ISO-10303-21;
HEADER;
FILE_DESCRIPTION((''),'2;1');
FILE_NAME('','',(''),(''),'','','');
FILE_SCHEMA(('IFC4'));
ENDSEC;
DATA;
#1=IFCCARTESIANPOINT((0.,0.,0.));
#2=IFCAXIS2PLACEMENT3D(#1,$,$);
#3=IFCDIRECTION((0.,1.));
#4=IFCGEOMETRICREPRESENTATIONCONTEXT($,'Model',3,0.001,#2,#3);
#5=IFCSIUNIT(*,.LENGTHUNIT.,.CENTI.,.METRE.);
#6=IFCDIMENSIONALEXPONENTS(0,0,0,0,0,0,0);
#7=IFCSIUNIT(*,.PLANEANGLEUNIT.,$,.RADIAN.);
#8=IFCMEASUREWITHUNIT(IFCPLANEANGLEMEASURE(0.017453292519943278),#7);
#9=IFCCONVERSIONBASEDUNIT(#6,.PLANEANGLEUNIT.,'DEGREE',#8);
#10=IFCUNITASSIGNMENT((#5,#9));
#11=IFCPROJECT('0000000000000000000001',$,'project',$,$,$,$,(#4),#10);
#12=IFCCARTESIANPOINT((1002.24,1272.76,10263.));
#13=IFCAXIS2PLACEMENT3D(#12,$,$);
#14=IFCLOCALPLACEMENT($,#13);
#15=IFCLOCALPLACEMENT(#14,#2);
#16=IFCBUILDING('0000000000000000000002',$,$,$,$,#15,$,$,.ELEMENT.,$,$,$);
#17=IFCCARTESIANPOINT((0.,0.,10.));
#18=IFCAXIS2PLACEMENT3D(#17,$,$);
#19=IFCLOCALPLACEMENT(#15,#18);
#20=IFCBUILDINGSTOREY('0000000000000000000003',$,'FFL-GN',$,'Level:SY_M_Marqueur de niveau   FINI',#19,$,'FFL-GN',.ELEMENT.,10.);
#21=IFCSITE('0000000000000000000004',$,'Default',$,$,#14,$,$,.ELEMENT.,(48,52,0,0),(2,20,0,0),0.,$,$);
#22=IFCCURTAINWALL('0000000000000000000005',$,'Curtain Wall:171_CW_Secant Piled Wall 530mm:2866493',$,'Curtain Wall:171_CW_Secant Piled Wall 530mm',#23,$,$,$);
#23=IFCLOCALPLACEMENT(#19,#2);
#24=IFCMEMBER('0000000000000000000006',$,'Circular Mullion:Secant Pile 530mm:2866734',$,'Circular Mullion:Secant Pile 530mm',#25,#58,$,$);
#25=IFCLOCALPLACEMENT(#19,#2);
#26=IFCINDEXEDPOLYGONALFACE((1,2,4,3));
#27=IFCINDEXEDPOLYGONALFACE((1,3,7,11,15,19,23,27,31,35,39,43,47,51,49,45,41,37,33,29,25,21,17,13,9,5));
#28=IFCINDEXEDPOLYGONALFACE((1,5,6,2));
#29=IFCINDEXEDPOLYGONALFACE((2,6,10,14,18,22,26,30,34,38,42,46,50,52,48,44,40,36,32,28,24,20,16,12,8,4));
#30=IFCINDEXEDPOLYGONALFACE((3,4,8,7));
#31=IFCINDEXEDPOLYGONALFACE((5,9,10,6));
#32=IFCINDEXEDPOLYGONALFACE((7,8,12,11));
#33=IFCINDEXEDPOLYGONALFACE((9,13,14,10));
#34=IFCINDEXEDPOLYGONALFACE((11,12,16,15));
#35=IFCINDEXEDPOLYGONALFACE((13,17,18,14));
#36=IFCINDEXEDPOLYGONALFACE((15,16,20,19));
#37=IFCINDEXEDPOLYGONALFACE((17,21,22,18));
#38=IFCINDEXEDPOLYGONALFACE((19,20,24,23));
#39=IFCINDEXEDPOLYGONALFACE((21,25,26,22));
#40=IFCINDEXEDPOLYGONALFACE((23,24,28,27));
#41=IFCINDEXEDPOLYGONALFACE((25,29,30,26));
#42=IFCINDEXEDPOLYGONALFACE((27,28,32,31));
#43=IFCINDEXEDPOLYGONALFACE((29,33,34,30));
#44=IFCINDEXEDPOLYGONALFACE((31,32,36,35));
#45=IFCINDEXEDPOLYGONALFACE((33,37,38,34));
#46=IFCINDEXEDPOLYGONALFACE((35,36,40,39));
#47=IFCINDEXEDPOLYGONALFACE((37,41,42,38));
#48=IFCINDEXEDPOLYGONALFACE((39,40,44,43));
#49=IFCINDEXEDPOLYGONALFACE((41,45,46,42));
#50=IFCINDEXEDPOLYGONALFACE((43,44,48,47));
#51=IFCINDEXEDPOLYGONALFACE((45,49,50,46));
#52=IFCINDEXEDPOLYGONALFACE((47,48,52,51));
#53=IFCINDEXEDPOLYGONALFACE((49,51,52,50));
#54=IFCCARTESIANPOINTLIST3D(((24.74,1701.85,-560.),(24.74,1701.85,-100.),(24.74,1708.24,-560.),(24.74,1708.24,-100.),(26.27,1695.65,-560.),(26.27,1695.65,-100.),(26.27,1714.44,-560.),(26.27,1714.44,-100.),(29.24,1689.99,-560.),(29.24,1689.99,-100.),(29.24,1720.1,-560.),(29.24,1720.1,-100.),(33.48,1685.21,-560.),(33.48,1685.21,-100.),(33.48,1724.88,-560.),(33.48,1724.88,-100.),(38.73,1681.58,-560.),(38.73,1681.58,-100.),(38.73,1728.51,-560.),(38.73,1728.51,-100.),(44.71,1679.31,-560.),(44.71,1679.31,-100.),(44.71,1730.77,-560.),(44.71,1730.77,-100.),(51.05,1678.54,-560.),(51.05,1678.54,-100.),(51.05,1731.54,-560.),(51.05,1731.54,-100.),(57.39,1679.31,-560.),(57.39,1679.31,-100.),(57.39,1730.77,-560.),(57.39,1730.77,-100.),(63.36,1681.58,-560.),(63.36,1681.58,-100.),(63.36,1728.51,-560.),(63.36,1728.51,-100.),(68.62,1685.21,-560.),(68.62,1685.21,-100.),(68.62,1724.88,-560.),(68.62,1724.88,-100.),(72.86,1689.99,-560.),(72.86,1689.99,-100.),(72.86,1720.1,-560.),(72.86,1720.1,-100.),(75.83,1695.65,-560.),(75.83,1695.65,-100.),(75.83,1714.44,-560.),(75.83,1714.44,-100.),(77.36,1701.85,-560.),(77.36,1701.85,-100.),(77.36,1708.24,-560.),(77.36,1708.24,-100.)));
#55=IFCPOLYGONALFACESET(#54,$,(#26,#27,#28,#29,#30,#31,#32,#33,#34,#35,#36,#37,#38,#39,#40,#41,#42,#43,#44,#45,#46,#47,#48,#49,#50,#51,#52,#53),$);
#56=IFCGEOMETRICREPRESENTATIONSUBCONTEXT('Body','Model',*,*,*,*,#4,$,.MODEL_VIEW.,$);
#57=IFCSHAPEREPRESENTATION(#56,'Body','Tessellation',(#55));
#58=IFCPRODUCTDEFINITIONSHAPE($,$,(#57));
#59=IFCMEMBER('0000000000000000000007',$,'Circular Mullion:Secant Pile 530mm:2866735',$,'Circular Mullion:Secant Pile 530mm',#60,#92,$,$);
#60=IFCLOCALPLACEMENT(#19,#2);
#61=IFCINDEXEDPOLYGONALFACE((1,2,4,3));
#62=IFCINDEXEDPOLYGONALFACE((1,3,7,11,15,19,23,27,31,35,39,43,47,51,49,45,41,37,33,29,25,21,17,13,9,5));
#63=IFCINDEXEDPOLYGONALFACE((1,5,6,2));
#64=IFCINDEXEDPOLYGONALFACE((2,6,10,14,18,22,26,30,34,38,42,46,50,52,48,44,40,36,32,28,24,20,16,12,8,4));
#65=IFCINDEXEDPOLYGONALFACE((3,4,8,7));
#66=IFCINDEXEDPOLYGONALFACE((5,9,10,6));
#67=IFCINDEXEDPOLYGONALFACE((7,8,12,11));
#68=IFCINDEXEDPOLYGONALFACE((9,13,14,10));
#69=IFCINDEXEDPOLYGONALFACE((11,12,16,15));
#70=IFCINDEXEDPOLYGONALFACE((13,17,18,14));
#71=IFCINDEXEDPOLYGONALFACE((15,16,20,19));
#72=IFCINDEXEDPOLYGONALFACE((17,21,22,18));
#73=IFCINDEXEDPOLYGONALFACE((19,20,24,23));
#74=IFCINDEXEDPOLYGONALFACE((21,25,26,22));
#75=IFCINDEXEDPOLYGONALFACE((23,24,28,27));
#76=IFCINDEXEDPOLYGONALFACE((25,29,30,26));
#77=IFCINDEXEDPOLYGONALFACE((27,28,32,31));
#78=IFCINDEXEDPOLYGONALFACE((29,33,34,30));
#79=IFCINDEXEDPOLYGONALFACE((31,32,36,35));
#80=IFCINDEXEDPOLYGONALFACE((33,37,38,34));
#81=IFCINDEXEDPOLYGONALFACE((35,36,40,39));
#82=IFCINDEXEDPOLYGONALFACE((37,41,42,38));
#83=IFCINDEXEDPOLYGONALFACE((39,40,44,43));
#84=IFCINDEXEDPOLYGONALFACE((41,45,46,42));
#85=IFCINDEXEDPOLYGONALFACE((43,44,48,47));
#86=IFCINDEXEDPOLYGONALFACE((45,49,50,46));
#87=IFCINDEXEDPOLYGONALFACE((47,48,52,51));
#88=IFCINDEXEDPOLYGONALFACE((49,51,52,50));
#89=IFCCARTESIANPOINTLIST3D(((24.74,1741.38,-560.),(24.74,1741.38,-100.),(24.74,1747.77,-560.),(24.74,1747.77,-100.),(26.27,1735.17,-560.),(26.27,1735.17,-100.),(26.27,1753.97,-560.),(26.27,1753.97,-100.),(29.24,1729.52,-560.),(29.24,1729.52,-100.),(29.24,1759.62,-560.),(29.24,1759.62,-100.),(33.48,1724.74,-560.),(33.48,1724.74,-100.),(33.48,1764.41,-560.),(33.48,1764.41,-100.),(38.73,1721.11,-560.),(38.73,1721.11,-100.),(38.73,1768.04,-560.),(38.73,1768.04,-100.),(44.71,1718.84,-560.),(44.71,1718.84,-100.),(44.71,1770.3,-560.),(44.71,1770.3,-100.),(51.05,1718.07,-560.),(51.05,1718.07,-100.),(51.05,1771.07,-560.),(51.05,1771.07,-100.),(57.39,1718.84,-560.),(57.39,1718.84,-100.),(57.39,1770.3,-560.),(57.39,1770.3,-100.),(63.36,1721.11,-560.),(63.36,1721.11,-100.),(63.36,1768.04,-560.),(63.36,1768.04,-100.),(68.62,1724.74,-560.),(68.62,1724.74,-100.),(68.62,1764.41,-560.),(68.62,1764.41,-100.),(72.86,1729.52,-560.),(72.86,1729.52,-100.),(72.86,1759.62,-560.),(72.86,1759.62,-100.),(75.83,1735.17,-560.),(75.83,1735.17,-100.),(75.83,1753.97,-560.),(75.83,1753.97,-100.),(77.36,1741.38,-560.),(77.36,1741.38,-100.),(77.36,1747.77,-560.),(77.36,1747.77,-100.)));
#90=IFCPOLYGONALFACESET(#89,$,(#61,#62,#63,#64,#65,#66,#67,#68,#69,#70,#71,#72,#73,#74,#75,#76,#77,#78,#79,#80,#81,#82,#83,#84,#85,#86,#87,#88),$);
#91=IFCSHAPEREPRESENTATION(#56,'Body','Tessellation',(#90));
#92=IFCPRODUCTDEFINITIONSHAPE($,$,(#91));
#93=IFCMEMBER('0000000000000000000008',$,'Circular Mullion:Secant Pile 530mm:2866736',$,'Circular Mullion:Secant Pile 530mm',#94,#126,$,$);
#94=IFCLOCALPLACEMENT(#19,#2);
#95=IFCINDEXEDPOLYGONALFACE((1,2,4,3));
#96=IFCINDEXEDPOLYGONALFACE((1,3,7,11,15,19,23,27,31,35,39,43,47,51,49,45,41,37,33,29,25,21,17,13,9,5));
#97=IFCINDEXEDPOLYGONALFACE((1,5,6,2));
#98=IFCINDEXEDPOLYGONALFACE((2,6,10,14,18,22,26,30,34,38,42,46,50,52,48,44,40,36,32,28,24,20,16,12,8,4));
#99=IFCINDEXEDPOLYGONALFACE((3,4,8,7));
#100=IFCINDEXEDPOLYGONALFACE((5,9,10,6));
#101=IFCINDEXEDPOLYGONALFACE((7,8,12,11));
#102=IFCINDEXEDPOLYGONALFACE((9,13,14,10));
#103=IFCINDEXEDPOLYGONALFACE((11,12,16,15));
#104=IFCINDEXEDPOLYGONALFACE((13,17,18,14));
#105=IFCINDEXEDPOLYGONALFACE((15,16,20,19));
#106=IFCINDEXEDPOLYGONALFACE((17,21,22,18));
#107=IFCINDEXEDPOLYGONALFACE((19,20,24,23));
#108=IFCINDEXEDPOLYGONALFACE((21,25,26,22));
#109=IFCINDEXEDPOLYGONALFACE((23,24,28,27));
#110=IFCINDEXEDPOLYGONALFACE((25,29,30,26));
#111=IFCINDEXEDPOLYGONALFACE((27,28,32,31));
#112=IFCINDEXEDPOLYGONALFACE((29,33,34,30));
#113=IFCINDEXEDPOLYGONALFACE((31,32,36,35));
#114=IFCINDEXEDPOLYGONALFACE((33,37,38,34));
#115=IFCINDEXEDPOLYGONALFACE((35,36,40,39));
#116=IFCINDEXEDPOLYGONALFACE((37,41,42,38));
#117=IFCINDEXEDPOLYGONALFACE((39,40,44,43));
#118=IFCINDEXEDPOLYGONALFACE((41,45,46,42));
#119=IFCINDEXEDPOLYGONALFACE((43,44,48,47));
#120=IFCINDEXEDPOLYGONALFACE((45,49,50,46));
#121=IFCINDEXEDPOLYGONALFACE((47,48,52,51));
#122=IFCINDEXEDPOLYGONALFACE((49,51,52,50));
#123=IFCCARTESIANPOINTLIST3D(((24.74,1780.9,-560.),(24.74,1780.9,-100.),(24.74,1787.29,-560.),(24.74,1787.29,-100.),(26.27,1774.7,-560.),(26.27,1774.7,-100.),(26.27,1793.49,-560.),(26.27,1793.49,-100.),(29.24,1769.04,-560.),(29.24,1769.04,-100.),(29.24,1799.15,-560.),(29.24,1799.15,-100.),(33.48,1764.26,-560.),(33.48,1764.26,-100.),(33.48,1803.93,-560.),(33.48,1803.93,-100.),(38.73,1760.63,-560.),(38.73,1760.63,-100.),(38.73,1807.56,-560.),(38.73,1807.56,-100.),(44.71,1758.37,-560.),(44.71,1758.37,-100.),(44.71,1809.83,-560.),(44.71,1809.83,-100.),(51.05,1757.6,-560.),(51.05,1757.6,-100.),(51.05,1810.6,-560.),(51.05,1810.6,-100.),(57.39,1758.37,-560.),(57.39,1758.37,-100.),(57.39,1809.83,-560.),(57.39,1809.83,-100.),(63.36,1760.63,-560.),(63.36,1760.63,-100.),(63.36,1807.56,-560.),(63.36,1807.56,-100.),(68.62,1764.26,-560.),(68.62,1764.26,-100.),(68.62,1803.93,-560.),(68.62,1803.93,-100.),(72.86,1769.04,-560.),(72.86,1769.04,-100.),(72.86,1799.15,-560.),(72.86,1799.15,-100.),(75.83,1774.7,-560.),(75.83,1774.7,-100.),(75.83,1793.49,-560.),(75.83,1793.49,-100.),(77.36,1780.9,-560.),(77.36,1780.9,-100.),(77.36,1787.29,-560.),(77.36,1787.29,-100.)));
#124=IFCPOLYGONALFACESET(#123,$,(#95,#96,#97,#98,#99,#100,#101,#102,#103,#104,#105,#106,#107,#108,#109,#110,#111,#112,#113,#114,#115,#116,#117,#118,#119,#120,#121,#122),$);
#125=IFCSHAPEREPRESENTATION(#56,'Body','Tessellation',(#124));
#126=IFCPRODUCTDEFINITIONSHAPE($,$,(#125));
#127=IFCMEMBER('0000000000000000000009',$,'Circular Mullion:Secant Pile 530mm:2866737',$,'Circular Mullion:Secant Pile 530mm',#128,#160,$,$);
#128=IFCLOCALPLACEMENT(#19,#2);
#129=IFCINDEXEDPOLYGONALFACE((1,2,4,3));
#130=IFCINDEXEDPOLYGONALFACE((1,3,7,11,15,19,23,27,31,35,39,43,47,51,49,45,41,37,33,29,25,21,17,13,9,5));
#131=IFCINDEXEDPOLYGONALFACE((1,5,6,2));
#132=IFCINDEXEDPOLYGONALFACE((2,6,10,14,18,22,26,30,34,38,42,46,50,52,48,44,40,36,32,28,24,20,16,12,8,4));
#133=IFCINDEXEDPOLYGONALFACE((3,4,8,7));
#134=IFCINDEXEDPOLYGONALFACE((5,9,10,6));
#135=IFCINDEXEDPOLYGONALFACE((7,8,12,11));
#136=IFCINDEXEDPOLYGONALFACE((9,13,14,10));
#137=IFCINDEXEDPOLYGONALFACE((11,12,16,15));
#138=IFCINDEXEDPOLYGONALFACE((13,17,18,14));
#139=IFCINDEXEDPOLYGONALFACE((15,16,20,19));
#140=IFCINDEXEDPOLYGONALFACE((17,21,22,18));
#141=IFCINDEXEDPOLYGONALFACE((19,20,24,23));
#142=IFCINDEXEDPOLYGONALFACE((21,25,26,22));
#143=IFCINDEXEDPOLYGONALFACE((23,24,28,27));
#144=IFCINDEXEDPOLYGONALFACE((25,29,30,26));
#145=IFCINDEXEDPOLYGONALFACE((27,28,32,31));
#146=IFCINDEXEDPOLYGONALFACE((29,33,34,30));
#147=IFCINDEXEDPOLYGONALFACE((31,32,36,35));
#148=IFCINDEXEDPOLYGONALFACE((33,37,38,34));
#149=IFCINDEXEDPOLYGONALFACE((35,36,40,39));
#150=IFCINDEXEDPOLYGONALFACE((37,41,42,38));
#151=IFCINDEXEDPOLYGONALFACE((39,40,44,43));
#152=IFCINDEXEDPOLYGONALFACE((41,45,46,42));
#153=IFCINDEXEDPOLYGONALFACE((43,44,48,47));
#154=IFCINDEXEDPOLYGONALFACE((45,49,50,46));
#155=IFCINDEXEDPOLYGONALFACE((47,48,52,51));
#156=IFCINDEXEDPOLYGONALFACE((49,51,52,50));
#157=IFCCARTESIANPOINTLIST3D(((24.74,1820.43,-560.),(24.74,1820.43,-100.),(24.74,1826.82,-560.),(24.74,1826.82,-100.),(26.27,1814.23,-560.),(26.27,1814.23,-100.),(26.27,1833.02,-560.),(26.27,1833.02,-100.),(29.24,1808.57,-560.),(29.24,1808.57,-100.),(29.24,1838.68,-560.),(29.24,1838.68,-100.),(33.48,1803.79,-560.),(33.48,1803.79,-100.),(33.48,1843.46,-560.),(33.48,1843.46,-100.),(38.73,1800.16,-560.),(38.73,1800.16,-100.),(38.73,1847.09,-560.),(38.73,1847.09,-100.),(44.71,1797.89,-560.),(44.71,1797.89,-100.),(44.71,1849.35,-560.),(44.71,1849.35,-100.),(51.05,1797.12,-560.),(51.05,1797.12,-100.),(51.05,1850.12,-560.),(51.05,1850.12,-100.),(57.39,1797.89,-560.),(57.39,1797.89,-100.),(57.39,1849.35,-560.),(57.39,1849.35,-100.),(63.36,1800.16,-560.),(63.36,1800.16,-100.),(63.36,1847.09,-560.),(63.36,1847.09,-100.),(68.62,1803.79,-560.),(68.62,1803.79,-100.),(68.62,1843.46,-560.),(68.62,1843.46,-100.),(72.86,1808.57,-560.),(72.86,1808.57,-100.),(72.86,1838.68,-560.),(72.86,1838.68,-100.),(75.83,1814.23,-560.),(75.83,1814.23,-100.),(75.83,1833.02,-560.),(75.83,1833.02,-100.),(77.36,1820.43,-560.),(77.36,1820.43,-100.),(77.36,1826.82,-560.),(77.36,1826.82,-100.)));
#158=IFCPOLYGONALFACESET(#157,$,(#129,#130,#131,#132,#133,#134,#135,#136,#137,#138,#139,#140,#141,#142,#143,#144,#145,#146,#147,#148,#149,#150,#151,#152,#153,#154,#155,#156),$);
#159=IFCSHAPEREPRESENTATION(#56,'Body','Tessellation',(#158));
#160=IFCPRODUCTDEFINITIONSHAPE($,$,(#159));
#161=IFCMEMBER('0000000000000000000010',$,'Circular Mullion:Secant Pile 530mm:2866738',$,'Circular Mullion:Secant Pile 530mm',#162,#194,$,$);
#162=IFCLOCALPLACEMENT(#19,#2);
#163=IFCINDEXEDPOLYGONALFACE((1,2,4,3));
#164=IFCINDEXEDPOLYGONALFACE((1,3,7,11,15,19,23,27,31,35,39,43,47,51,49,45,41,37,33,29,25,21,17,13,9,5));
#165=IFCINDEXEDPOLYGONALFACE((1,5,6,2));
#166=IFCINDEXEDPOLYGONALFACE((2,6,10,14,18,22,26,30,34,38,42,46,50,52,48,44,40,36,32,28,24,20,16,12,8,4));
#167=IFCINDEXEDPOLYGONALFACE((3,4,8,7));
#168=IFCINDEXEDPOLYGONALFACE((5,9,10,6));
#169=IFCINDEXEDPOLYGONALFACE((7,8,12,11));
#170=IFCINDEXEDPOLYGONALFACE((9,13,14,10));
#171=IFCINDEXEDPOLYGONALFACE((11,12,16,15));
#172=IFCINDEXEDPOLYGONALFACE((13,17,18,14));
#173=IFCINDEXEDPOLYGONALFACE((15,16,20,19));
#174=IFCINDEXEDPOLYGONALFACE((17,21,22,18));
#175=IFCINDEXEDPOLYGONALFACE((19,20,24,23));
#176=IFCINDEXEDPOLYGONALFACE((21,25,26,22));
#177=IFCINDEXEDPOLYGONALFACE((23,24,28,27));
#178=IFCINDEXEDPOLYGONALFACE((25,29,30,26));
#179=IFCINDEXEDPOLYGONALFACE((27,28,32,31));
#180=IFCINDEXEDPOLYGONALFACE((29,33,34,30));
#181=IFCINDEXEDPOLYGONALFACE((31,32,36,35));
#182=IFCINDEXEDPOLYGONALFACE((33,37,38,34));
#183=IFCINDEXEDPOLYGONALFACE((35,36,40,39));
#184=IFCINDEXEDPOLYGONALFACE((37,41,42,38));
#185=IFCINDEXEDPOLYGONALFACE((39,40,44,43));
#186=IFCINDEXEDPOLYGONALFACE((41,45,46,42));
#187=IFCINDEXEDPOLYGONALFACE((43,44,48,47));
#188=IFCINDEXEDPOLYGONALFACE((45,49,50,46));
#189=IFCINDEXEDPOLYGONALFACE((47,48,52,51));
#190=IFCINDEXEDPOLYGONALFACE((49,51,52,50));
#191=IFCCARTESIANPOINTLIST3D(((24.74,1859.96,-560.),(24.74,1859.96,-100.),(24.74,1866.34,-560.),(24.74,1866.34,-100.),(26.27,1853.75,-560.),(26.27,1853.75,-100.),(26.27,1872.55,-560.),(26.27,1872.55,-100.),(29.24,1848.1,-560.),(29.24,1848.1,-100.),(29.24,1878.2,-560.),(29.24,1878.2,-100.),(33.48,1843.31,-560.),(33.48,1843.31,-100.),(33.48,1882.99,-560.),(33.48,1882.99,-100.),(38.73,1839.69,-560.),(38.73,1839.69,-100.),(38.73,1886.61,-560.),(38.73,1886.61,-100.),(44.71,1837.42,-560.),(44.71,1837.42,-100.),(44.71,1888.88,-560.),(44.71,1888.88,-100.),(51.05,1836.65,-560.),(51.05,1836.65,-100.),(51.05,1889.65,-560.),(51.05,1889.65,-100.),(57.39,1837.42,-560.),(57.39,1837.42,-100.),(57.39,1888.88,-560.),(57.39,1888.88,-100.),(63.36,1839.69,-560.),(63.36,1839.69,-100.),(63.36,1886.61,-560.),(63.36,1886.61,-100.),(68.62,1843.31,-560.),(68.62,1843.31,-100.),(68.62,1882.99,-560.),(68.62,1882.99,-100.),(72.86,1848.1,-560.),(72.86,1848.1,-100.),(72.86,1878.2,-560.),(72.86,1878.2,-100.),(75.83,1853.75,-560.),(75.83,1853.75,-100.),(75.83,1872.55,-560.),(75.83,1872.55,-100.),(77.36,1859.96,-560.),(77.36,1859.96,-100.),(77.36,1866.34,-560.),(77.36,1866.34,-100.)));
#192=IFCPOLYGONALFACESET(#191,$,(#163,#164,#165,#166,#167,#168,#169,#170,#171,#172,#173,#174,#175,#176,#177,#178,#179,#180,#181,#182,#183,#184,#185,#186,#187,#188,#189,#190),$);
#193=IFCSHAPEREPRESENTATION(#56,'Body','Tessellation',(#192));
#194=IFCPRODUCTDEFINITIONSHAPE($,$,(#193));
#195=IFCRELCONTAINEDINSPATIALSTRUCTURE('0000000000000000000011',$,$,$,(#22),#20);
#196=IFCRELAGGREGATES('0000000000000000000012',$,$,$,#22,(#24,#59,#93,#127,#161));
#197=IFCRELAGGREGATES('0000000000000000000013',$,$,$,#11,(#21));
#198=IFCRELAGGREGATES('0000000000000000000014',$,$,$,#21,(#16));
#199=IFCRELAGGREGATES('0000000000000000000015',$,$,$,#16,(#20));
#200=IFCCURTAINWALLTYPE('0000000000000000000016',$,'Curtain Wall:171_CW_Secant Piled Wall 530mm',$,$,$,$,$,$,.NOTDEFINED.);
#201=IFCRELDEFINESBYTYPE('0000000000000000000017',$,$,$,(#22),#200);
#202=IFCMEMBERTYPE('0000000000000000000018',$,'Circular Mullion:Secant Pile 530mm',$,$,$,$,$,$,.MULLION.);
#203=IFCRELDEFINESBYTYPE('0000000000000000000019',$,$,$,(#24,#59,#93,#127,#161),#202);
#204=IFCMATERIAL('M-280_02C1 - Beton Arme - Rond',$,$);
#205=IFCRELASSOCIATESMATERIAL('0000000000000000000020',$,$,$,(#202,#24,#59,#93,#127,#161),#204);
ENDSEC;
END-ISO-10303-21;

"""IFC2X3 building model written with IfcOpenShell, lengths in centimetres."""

from ifc_helpers import new_model, entity, si_unit, converted_unit, direction, frame, frame_2d, origin, place, context, subcontext, project, spatial, circle, extrude, source, transform, mapped, material, type_object, type_shapes, element, aggregate, save


model = new_model("IFC2X3")

# Units and contexts
model_context = context("Model", 3, precision=0.001, world=origin(), true_north=direction((0.0, 1.0)))
body_context = subcontext(model_context, "Body", "Model", "MODEL_VIEW")
ifc_project = project(units=[si_unit("LENGTHUNIT", "METRE", prefix="CENTI"), converted_unit("PLANEANGLEUNIT", "DEGREE", entity("IfcPlaneAngleMeasure", 0.017453292519943278), si_unit("PLANEANGLEUNIT", "RADIAN"), dimensions=[0, 0, 0, 0, 0, 0, 0])], contexts=[model_context])

# Site, building, storey
site_placement = place(None, frame((1002.24, 1272.76, 10263.0)))
site = spatial("IfcSite", under=ifc_project, at=site_placement, Name="Default", CompositionType="ELEMENT", RefLatitude=(48, 52, 0, 0), RefLongitude=(2, 20, 0, 0), RefElevation=0.0)
building_placement = place(site_placement, origin())
building = spatial("IfcBuilding", under=site, at=building_placement, CompositionType="ELEMENT")
storey_placement = place(building_placement, frame((0.0, 0.0, 10.0)))
storey = spatial("IfcBuildingStorey", under=building, at=storey_placement, Name="FFL-GN", ObjectType="Level:SY_M_Marqueur de niveau   FINI", LongName="FFL-GN", CompositionType="ELEMENT", Elevation=10.0)

# Curtain wall, members
curtain_wall_type = type_object("IfcCurtainWallType", Name="Curtain Wall:171_CW_Secant Piled Wall 530mm", PredefinedType="NOTDEFINED")
curtain_wall_placement = place(storey_placement, frame((0.0, 0.0, -10.0)))
curtain_wall = element("IfcCurtainWall", 1, at=curtain_wall_placement, inside=storey, type_object=curtain_wall_type, Name="Curtain Wall:171_CW_Secant Piled Wall 530mm:2866493", ObjectType="Curtain Wall:171_CW_Secant Piled Wall 530mm")
ifc_material_1 = material(Name="M-280_02C1 - Beton Arme - Rond")
member_type = type_object("IfcMemberType", Name="Circular Mullion:Secant Pile 530mm", PredefinedType="MULLION", material=ifc_material_1)
shared_shape = source(origin(), body_context, "Body", "SweptSolid", [
    extrude(circle(Radius=26.5, at=frame_2d((0.0, 0.0), x_axis=(1.0, 0.0))), frame((0.0, 0.0, -460.0)), (0.0, 0.0, 1.0), 460.0),
])
type_shapes(member_type, [shared_shape])
member_1_placement = place(curtain_wall_placement, frame((51.05, 1705.04, -550.0), z_axis=(0.0, 0.0, -1.0), x_axis=(0.0, 1.0, 0.0)))
member_1 = element("IfcMember", 2, at=member_1_placement, type_object=member_type, material=ifc_material_1, Name="Circular Mullion:Secant Pile 530mm:2866734", ObjectType="Circular Mullion:Secant Pile 530mm", context=body_context, shape_type="MappedRepresentation", body=[
    mapped(shared_shape, transform((0.0, 0.0, 0.0), scale=1.0)),
])
member_2_placement = place(curtain_wall_placement, frame((51.05, 1744.57, -550.0), z_axis=(0.0, 0.0, -1.0), x_axis=(0.0, 1.0, 0.0)))
member_2 = element("IfcMember", 3, at=member_2_placement, type_object=member_type, material=ifc_material_1, Name="Circular Mullion:Secant Pile 530mm:2866735", ObjectType="Circular Mullion:Secant Pile 530mm", context=body_context, shape_type="MappedRepresentation", body=[
    mapped(shared_shape, transform((0.0, 0.0, 0.0), scale=1.0)),
])
member_3_placement = place(curtain_wall_placement, frame((51.05, 1784.1, -550.0), z_axis=(0.0, 0.0, -1.0), x_axis=(0.0, 1.0, 0.0)))
member_3 = element("IfcMember", 4, at=member_3_placement, type_object=member_type, material=ifc_material_1, Name="Circular Mullion:Secant Pile 530mm:2866736", ObjectType="Circular Mullion:Secant Pile 530mm", context=body_context, shape_type="MappedRepresentation", body=[
    mapped(shared_shape, transform((0.0, 0.0, 0.0), scale=1.0)),
])
member_4_placement = place(curtain_wall_placement, frame((51.05, 1823.62, -550.0), z_axis=(0.0, 0.0, -1.0), x_axis=(0.0, 1.0, 0.0)))
member_4 = element("IfcMember", 5, at=member_4_placement, type_object=member_type, material=ifc_material_1, Name="Circular Mullion:Secant Pile 530mm:2866737", ObjectType="Circular Mullion:Secant Pile 530mm", context=body_context, shape_type="MappedRepresentation", body=[
    mapped(shared_shape, transform((0.0, 0.0, 0.0), scale=1.0)),
])
member_5_placement = place(curtain_wall_placement, frame((51.05, 1863.15, -550.0), z_axis=(0.0, 0.0, -1.0), x_axis=(0.0, 1.0, 0.0)))
member_5 = element("IfcMember", 6, at=member_5_placement, type_object=member_type, material=ifc_material_1, Name="Circular Mullion:Secant Pile 530mm:2866738", ObjectType="Circular Mullion:Secant Pile 530mm", context=body_context, shape_type="MappedRepresentation", body=[
    mapped(shared_shape, transform((0.0, 0.0, 0.0), scale=1.0)),
])
aggregate(curtain_wall, [member_1, member_2, member_3, member_4, member_5])

save(model, "model.ifc")
